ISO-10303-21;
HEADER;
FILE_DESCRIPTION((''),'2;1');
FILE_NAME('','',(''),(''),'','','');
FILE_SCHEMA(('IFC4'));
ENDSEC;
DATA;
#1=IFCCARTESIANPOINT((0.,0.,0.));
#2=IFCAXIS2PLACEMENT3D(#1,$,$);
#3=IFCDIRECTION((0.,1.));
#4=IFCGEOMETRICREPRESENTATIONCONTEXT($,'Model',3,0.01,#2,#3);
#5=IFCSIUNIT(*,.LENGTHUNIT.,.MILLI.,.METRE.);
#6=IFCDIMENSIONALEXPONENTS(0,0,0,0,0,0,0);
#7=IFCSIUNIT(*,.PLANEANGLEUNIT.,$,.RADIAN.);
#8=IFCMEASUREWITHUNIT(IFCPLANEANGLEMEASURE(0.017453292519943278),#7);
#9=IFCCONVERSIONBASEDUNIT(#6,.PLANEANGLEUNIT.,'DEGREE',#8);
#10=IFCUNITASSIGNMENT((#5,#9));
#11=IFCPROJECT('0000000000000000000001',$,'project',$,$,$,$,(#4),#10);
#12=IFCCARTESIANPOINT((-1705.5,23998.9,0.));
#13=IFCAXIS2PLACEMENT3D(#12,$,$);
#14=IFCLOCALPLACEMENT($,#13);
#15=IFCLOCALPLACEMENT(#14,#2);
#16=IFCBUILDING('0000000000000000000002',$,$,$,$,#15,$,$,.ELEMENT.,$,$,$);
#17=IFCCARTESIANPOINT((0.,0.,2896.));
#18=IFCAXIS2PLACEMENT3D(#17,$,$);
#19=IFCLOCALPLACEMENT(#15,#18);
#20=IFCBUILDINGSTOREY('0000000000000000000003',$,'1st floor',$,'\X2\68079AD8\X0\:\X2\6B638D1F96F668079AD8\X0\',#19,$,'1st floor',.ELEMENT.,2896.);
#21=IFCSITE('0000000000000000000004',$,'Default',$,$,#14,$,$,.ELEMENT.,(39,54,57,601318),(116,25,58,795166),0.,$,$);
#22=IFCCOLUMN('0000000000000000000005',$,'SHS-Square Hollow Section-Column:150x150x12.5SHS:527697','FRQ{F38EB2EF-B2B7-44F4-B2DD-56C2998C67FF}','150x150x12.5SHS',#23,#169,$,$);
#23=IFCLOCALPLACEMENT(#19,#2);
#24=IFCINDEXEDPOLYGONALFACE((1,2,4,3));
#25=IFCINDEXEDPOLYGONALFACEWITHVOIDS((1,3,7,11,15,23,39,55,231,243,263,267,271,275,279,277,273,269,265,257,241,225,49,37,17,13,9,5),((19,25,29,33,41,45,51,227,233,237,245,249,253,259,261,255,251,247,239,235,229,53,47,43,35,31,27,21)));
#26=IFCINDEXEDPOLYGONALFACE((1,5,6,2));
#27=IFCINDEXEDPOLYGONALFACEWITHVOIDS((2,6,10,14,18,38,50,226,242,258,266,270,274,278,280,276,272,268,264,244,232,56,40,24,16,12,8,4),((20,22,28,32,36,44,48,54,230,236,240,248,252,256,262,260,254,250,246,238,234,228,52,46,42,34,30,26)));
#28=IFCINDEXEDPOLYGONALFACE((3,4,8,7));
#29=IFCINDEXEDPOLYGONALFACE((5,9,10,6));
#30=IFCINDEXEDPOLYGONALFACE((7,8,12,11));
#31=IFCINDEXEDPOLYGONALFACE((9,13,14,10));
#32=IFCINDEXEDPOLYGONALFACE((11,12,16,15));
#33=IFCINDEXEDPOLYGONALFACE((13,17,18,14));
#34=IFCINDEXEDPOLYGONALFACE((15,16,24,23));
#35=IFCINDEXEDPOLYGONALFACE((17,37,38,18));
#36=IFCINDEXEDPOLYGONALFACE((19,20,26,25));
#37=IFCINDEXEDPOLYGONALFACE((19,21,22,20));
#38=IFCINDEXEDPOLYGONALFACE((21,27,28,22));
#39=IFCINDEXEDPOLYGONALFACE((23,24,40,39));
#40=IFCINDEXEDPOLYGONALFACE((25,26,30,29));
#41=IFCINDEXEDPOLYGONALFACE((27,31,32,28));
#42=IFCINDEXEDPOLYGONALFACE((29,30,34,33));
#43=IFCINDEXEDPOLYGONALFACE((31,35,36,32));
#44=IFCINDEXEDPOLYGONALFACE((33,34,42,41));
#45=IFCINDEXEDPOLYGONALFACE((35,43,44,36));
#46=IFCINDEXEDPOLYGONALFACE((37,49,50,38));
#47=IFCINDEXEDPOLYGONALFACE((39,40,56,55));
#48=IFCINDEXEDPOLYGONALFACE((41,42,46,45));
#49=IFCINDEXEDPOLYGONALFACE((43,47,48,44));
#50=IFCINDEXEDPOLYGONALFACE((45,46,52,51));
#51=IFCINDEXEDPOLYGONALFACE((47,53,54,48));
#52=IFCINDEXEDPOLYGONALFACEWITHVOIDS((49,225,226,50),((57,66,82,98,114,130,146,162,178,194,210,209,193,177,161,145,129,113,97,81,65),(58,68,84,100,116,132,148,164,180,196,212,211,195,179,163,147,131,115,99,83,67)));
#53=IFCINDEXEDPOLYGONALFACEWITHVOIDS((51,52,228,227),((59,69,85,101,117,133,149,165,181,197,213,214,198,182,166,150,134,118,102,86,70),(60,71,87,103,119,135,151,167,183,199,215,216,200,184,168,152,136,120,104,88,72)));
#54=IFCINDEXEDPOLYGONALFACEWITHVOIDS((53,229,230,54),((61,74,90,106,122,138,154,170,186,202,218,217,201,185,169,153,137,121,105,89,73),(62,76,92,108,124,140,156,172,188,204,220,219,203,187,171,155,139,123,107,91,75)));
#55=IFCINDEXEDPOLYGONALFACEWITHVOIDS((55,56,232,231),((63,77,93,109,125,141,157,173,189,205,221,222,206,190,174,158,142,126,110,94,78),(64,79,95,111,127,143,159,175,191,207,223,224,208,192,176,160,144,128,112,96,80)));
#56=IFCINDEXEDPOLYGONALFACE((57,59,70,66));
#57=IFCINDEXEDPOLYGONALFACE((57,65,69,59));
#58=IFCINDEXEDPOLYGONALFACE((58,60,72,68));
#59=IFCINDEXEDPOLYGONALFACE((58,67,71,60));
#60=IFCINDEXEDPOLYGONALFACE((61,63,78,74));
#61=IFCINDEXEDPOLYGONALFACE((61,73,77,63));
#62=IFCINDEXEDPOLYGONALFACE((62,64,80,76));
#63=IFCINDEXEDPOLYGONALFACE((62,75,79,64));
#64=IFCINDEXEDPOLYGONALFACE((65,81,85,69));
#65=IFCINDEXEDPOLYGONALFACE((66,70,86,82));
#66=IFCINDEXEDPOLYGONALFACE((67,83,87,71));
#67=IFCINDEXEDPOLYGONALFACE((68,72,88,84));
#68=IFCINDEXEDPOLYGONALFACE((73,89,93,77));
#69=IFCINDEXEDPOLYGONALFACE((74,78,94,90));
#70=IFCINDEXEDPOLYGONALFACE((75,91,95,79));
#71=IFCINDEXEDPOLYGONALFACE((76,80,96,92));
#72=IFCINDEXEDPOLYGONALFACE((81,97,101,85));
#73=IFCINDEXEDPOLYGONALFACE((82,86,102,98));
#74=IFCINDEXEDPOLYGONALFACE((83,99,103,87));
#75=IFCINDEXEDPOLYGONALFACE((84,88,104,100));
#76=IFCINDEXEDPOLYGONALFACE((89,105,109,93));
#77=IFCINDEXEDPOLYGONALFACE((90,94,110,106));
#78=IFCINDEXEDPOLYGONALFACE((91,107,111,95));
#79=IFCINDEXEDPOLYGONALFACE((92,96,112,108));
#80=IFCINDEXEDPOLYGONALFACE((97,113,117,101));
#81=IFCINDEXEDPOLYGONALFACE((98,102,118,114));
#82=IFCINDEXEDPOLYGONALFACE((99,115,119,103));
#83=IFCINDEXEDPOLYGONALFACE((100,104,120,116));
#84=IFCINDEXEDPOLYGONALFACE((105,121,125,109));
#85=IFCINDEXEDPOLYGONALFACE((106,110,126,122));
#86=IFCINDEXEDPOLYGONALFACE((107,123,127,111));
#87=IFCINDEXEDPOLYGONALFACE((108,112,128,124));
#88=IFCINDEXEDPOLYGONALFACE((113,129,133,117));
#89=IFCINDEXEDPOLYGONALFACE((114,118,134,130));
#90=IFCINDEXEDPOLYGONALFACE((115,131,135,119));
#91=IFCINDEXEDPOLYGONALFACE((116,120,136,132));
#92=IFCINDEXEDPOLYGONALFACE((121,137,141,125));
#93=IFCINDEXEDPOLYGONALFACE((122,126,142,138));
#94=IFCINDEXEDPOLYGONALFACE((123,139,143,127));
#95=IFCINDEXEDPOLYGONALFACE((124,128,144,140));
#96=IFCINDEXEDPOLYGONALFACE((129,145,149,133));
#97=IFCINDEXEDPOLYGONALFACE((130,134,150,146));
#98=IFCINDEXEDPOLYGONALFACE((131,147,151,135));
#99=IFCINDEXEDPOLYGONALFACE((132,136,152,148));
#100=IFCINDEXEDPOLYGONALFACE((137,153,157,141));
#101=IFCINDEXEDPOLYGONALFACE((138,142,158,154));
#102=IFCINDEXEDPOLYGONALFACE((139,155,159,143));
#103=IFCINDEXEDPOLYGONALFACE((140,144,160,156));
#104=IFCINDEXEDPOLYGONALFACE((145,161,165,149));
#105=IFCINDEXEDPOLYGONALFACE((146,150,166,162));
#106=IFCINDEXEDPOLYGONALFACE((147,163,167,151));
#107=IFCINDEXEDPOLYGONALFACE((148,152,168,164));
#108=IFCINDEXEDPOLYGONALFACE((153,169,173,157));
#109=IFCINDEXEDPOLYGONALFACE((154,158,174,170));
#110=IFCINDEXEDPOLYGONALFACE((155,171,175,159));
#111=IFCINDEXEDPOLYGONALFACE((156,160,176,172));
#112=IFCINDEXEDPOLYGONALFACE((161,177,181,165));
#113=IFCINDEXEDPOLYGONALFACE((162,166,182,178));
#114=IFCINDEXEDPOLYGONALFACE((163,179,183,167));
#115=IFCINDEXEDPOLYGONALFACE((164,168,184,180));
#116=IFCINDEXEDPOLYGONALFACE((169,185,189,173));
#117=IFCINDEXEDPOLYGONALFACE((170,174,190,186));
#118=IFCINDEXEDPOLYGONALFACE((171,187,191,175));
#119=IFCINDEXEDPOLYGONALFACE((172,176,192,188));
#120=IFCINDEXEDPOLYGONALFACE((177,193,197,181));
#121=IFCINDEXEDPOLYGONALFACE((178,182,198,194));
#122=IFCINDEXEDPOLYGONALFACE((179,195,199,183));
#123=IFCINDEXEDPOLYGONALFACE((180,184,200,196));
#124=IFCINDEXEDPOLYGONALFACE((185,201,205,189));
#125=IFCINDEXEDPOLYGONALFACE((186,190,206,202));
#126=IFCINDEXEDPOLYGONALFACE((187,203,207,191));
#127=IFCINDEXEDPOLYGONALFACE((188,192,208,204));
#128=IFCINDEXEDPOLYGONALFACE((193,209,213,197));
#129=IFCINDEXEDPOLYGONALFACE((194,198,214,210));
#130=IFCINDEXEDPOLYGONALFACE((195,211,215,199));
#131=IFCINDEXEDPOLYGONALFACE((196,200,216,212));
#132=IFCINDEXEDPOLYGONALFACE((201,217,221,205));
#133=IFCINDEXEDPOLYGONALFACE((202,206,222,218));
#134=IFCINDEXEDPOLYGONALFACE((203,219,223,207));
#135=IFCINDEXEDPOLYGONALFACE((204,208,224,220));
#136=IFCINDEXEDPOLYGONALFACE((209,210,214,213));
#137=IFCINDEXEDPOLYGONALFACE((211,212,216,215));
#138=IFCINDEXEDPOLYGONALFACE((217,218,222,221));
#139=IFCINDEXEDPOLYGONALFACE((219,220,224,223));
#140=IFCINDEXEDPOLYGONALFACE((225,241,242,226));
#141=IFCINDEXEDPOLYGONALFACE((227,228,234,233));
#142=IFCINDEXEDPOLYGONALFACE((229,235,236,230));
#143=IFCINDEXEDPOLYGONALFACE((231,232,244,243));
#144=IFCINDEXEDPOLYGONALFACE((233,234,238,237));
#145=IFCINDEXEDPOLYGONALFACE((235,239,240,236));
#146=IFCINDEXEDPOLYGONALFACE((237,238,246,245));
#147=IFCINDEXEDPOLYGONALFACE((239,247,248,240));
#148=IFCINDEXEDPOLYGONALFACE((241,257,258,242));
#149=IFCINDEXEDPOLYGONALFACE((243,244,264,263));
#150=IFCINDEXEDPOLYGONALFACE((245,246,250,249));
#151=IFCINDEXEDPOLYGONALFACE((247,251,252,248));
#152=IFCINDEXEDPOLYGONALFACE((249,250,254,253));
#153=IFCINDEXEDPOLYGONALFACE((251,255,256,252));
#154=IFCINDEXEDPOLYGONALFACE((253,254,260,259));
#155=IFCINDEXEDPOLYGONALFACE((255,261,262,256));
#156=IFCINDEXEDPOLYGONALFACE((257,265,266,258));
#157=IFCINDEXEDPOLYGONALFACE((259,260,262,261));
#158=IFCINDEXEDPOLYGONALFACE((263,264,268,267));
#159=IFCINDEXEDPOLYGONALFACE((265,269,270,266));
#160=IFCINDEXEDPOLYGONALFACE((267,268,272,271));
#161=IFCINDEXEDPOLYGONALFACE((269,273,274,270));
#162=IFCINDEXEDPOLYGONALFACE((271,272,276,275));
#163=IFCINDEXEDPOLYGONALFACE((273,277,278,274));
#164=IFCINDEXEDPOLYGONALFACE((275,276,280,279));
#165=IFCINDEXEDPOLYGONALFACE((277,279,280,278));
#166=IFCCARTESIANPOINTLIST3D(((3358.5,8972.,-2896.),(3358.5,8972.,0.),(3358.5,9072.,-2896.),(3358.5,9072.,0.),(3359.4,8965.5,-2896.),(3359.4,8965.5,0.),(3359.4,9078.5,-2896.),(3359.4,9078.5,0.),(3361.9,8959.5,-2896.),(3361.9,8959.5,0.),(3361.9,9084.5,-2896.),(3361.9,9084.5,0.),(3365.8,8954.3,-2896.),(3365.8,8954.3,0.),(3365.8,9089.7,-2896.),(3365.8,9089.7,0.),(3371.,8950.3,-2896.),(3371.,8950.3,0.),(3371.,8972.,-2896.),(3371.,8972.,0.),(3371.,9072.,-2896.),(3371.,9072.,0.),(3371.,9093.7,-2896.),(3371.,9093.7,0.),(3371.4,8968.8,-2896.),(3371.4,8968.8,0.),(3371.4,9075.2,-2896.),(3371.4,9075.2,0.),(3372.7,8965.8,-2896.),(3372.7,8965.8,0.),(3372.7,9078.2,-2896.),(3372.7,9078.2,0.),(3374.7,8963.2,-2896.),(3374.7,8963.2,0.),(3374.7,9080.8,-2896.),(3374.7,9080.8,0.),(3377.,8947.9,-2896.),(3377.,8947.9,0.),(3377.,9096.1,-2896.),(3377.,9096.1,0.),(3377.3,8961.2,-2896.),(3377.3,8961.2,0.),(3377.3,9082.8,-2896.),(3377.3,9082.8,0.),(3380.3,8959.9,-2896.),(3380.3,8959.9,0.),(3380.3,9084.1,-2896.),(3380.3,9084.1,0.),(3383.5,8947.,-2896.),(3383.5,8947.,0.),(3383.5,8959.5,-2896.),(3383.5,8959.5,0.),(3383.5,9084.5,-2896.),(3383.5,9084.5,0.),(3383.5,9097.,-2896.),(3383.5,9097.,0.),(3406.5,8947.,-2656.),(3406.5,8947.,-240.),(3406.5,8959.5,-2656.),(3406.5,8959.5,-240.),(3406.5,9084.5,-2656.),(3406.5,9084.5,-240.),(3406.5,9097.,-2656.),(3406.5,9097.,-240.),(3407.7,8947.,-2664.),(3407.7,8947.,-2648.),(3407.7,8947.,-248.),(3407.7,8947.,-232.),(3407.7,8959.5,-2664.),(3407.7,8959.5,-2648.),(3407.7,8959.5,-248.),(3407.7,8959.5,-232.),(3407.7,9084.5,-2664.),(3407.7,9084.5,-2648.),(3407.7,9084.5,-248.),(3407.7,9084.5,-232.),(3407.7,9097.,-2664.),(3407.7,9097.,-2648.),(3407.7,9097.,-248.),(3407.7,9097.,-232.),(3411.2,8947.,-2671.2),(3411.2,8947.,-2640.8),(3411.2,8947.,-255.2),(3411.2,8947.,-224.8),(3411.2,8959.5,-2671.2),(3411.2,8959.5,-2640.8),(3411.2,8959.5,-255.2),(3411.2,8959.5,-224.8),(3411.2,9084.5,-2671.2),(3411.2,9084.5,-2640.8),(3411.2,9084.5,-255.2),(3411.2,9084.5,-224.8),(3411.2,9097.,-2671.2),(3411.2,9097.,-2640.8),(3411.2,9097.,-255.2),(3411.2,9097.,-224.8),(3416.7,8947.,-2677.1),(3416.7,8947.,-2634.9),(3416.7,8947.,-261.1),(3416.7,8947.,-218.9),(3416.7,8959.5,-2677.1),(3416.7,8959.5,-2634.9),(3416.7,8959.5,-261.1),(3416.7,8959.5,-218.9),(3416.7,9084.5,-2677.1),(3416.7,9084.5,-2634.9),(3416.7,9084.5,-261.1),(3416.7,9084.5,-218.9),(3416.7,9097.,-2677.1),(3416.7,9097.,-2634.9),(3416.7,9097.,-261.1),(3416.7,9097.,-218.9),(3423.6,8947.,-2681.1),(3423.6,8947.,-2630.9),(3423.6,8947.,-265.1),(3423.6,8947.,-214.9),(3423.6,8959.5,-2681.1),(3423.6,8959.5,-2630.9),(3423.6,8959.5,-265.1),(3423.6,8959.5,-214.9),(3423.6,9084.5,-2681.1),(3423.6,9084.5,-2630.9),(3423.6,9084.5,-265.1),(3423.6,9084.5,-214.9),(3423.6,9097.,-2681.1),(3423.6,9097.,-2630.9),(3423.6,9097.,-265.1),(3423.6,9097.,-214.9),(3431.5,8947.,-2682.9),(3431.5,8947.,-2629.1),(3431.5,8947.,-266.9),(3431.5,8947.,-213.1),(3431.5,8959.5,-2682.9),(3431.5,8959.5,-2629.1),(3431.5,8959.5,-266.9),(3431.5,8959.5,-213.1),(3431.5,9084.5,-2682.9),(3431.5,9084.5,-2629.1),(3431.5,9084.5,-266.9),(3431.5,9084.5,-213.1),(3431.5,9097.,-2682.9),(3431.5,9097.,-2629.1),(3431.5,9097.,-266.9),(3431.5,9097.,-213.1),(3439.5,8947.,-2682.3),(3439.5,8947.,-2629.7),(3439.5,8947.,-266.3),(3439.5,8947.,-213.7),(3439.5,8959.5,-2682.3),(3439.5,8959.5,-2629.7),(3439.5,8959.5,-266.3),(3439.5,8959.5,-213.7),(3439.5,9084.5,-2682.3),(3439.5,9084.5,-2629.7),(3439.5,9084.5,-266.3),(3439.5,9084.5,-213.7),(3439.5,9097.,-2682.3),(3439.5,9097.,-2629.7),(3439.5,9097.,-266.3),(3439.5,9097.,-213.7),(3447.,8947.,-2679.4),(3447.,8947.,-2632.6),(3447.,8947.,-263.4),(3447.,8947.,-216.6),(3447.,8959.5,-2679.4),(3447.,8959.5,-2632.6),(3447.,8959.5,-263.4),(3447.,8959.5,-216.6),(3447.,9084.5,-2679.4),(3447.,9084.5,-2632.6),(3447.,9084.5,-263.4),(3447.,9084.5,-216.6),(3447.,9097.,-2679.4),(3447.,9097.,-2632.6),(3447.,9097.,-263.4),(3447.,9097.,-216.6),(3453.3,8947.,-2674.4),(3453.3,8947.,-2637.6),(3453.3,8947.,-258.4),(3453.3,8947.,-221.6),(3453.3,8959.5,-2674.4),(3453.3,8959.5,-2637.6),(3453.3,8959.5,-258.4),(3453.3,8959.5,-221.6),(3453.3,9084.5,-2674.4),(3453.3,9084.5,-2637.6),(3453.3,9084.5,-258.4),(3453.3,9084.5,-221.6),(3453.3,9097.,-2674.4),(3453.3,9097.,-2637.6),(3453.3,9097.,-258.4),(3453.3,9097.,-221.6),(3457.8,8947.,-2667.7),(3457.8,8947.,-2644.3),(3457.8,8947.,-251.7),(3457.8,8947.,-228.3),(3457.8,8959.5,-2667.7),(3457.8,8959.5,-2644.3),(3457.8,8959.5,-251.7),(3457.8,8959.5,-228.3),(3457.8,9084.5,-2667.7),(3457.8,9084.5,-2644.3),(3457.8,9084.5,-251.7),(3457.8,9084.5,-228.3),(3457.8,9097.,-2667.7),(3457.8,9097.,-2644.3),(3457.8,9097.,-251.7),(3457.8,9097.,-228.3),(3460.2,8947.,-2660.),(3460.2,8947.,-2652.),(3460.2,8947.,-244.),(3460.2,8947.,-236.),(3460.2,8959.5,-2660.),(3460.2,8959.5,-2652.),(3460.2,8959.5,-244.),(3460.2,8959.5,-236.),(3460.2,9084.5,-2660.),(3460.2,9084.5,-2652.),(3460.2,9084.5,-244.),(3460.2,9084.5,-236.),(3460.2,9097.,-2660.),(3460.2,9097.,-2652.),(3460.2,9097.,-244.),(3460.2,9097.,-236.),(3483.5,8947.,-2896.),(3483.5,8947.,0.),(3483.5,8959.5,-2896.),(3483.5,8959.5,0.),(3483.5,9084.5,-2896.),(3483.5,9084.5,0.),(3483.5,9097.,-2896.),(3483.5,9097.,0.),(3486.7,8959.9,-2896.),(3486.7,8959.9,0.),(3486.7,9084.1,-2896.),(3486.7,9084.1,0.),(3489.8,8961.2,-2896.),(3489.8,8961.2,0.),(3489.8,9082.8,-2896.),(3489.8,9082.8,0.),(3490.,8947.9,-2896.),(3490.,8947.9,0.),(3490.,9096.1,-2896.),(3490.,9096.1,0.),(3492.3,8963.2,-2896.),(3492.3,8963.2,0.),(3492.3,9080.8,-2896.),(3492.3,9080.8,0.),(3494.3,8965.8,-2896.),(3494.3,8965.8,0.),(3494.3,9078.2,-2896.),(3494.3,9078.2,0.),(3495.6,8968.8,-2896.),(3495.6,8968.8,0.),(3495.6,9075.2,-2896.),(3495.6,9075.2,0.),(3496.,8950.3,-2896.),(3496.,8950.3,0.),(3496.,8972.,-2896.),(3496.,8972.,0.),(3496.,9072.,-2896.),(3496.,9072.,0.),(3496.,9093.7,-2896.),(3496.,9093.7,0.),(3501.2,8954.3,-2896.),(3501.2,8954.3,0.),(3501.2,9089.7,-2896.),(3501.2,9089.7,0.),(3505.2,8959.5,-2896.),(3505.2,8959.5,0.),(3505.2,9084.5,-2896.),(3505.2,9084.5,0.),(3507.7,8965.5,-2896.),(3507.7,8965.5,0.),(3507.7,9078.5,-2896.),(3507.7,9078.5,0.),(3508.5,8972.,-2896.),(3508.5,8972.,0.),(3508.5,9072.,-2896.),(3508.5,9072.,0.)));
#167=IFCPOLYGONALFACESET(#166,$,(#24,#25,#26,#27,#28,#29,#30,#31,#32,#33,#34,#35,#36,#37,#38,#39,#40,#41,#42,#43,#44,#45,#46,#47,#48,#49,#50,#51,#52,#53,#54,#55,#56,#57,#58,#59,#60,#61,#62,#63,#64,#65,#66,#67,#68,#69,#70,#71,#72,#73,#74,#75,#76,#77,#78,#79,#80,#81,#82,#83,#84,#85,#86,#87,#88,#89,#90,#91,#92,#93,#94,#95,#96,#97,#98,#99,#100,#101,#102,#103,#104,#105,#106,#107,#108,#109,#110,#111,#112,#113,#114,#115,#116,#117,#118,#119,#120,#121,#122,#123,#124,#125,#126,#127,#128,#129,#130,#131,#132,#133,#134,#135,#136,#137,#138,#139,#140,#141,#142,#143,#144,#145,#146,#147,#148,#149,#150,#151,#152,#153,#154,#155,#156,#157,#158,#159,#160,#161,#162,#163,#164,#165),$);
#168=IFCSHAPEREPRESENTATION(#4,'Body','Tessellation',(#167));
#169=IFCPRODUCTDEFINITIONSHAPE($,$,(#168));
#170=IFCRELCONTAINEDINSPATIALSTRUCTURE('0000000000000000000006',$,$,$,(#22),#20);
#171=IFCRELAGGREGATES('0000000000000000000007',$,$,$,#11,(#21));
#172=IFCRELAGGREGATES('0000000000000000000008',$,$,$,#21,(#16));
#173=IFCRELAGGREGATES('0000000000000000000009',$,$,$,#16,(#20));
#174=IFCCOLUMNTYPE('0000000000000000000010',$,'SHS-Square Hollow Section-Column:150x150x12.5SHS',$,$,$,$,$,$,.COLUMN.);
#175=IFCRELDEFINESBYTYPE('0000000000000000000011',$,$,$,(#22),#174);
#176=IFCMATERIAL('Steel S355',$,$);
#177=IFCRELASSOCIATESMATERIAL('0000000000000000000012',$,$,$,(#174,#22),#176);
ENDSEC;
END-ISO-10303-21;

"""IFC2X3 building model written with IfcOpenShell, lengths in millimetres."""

from ifc_helpers import new_model, entity, si_unit, converted_unit, direction, frame, frame_2d, origin, origin_2d, place, context, project, spatial, circle_curve, hollow_rectangle, outline, extrude, material, type_object, element, save


model = new_model("IFC2X3")

# Units and contexts
model_context = context("Model", 3, precision=0.01, world=origin(), true_north=direction((0.0, 1.0)))
ifc_project = project(units=[si_unit("LENGTHUNIT", "METRE", prefix="MILLI"), converted_unit("PLANEANGLEUNIT", "DEGREE", entity("IfcPlaneAngleMeasure", 0.017453292519943278), si_unit("PLANEANGLEUNIT", "RADIAN"), dimensions=[0, 0, 0, 0, 0, 0, 0])], contexts=[model_context])

# Site, building, storey
site_placement = place(None, frame((-1705.5, 23998.9, 0.0)))
site = spatial("IfcSite", under=ifc_project, at=site_placement, Name="Default", CompositionType="ELEMENT", RefLatitude=(39, 54, 57, 601318), RefLongitude=(116, 25, 58, 795166), RefElevation=0.0)
building_placement = place(site_placement, origin())
building = spatial("IfcBuilding", under=site, at=building_placement, CompositionType="ELEMENT")
storey_placement = place(building_placement, frame((0.0, 0.0, 2896.0)))
storey = spatial("IfcBuildingStorey", under=building, at=storey_placement, Name="1st floor", ObjectType="标高:正负零标高", LongName="1st floor", CompositionType="ELEMENT", Elevation=2896.0)

# Column, openings
ifc_material_1 = material(Name="Steel S355")
column_type_1 = type_object("IfcColumnType", Name="SHS-Square Hollow Section-Column:150x150x12.5SHS", PredefinedType="COLUMN", material=ifc_material_1)
column_1_placement = place(storey_placement, frame((3433.5, 9022.0, 0.0), z_axis=(0.0, 0.0, 1.0), x_axis=(0.0, -1.0, 0.0)))
column_1 = element("IfcColumn", 1, at=column_1_placement, inside=storey, type_object=column_type_1, material=ifc_material_1, Name="SHS-Square Hollow Section-Column:150x150x12.5SHS:527697", Description="FRQ{F38EB2EF-B2B7-44F4-B2DD-56C2998C67FF}", ObjectType="150x150x12.5SHS", context=model_context, shape_type="SweptSolid", body=[
    extrude(hollow_rectangle(XDim=150.0, YDim=150.0, WallThickness=12.5, InnerFilletRadius=12.5, OuterFilletRadius=25.0, at=origin_2d()), origin(), (0.0, 0.0, -1.0), 2896.0),
])
opening_1_placement = place(column_1_placement, frame((175.1, 0.0, 0.0), z_axis=(-1.0, 0.0, 0.0), x_axis=(0.0, -1.0, 0.0)))
element("IfcOpeningElement", 2, at=opening_1_placement, cuts=column_1, ObjectType="Opening", context=model_context, shape_type="SweptSolid", body=[
    extrude(outline(circle_curve(frame_2d((0.0, -240.0), x_axis=(1.0, 0.0)), 27.0)), origin(), (0.0, 0.0, 1.0), 350.2),
])
opening_2_placement = place(column_1_placement, frame((175.1, 0.0, -2896.0), z_axis=(-1.0, 0.0, 0.0), x_axis=(0.0, -1.0, 0.0)))
element("IfcOpeningElement", 3, at=opening_2_placement, cuts=column_1, ObjectType="Opening", context=model_context, shape_type="SweptSolid", body=[
    extrude(outline(circle_curve(frame_2d((0.0, 240.0), x_axis=(1.0, 0.0)), 27.0)), origin(), (0.0, 0.0, 1.0), 350.2),
])

save(model, "model.ifc")
